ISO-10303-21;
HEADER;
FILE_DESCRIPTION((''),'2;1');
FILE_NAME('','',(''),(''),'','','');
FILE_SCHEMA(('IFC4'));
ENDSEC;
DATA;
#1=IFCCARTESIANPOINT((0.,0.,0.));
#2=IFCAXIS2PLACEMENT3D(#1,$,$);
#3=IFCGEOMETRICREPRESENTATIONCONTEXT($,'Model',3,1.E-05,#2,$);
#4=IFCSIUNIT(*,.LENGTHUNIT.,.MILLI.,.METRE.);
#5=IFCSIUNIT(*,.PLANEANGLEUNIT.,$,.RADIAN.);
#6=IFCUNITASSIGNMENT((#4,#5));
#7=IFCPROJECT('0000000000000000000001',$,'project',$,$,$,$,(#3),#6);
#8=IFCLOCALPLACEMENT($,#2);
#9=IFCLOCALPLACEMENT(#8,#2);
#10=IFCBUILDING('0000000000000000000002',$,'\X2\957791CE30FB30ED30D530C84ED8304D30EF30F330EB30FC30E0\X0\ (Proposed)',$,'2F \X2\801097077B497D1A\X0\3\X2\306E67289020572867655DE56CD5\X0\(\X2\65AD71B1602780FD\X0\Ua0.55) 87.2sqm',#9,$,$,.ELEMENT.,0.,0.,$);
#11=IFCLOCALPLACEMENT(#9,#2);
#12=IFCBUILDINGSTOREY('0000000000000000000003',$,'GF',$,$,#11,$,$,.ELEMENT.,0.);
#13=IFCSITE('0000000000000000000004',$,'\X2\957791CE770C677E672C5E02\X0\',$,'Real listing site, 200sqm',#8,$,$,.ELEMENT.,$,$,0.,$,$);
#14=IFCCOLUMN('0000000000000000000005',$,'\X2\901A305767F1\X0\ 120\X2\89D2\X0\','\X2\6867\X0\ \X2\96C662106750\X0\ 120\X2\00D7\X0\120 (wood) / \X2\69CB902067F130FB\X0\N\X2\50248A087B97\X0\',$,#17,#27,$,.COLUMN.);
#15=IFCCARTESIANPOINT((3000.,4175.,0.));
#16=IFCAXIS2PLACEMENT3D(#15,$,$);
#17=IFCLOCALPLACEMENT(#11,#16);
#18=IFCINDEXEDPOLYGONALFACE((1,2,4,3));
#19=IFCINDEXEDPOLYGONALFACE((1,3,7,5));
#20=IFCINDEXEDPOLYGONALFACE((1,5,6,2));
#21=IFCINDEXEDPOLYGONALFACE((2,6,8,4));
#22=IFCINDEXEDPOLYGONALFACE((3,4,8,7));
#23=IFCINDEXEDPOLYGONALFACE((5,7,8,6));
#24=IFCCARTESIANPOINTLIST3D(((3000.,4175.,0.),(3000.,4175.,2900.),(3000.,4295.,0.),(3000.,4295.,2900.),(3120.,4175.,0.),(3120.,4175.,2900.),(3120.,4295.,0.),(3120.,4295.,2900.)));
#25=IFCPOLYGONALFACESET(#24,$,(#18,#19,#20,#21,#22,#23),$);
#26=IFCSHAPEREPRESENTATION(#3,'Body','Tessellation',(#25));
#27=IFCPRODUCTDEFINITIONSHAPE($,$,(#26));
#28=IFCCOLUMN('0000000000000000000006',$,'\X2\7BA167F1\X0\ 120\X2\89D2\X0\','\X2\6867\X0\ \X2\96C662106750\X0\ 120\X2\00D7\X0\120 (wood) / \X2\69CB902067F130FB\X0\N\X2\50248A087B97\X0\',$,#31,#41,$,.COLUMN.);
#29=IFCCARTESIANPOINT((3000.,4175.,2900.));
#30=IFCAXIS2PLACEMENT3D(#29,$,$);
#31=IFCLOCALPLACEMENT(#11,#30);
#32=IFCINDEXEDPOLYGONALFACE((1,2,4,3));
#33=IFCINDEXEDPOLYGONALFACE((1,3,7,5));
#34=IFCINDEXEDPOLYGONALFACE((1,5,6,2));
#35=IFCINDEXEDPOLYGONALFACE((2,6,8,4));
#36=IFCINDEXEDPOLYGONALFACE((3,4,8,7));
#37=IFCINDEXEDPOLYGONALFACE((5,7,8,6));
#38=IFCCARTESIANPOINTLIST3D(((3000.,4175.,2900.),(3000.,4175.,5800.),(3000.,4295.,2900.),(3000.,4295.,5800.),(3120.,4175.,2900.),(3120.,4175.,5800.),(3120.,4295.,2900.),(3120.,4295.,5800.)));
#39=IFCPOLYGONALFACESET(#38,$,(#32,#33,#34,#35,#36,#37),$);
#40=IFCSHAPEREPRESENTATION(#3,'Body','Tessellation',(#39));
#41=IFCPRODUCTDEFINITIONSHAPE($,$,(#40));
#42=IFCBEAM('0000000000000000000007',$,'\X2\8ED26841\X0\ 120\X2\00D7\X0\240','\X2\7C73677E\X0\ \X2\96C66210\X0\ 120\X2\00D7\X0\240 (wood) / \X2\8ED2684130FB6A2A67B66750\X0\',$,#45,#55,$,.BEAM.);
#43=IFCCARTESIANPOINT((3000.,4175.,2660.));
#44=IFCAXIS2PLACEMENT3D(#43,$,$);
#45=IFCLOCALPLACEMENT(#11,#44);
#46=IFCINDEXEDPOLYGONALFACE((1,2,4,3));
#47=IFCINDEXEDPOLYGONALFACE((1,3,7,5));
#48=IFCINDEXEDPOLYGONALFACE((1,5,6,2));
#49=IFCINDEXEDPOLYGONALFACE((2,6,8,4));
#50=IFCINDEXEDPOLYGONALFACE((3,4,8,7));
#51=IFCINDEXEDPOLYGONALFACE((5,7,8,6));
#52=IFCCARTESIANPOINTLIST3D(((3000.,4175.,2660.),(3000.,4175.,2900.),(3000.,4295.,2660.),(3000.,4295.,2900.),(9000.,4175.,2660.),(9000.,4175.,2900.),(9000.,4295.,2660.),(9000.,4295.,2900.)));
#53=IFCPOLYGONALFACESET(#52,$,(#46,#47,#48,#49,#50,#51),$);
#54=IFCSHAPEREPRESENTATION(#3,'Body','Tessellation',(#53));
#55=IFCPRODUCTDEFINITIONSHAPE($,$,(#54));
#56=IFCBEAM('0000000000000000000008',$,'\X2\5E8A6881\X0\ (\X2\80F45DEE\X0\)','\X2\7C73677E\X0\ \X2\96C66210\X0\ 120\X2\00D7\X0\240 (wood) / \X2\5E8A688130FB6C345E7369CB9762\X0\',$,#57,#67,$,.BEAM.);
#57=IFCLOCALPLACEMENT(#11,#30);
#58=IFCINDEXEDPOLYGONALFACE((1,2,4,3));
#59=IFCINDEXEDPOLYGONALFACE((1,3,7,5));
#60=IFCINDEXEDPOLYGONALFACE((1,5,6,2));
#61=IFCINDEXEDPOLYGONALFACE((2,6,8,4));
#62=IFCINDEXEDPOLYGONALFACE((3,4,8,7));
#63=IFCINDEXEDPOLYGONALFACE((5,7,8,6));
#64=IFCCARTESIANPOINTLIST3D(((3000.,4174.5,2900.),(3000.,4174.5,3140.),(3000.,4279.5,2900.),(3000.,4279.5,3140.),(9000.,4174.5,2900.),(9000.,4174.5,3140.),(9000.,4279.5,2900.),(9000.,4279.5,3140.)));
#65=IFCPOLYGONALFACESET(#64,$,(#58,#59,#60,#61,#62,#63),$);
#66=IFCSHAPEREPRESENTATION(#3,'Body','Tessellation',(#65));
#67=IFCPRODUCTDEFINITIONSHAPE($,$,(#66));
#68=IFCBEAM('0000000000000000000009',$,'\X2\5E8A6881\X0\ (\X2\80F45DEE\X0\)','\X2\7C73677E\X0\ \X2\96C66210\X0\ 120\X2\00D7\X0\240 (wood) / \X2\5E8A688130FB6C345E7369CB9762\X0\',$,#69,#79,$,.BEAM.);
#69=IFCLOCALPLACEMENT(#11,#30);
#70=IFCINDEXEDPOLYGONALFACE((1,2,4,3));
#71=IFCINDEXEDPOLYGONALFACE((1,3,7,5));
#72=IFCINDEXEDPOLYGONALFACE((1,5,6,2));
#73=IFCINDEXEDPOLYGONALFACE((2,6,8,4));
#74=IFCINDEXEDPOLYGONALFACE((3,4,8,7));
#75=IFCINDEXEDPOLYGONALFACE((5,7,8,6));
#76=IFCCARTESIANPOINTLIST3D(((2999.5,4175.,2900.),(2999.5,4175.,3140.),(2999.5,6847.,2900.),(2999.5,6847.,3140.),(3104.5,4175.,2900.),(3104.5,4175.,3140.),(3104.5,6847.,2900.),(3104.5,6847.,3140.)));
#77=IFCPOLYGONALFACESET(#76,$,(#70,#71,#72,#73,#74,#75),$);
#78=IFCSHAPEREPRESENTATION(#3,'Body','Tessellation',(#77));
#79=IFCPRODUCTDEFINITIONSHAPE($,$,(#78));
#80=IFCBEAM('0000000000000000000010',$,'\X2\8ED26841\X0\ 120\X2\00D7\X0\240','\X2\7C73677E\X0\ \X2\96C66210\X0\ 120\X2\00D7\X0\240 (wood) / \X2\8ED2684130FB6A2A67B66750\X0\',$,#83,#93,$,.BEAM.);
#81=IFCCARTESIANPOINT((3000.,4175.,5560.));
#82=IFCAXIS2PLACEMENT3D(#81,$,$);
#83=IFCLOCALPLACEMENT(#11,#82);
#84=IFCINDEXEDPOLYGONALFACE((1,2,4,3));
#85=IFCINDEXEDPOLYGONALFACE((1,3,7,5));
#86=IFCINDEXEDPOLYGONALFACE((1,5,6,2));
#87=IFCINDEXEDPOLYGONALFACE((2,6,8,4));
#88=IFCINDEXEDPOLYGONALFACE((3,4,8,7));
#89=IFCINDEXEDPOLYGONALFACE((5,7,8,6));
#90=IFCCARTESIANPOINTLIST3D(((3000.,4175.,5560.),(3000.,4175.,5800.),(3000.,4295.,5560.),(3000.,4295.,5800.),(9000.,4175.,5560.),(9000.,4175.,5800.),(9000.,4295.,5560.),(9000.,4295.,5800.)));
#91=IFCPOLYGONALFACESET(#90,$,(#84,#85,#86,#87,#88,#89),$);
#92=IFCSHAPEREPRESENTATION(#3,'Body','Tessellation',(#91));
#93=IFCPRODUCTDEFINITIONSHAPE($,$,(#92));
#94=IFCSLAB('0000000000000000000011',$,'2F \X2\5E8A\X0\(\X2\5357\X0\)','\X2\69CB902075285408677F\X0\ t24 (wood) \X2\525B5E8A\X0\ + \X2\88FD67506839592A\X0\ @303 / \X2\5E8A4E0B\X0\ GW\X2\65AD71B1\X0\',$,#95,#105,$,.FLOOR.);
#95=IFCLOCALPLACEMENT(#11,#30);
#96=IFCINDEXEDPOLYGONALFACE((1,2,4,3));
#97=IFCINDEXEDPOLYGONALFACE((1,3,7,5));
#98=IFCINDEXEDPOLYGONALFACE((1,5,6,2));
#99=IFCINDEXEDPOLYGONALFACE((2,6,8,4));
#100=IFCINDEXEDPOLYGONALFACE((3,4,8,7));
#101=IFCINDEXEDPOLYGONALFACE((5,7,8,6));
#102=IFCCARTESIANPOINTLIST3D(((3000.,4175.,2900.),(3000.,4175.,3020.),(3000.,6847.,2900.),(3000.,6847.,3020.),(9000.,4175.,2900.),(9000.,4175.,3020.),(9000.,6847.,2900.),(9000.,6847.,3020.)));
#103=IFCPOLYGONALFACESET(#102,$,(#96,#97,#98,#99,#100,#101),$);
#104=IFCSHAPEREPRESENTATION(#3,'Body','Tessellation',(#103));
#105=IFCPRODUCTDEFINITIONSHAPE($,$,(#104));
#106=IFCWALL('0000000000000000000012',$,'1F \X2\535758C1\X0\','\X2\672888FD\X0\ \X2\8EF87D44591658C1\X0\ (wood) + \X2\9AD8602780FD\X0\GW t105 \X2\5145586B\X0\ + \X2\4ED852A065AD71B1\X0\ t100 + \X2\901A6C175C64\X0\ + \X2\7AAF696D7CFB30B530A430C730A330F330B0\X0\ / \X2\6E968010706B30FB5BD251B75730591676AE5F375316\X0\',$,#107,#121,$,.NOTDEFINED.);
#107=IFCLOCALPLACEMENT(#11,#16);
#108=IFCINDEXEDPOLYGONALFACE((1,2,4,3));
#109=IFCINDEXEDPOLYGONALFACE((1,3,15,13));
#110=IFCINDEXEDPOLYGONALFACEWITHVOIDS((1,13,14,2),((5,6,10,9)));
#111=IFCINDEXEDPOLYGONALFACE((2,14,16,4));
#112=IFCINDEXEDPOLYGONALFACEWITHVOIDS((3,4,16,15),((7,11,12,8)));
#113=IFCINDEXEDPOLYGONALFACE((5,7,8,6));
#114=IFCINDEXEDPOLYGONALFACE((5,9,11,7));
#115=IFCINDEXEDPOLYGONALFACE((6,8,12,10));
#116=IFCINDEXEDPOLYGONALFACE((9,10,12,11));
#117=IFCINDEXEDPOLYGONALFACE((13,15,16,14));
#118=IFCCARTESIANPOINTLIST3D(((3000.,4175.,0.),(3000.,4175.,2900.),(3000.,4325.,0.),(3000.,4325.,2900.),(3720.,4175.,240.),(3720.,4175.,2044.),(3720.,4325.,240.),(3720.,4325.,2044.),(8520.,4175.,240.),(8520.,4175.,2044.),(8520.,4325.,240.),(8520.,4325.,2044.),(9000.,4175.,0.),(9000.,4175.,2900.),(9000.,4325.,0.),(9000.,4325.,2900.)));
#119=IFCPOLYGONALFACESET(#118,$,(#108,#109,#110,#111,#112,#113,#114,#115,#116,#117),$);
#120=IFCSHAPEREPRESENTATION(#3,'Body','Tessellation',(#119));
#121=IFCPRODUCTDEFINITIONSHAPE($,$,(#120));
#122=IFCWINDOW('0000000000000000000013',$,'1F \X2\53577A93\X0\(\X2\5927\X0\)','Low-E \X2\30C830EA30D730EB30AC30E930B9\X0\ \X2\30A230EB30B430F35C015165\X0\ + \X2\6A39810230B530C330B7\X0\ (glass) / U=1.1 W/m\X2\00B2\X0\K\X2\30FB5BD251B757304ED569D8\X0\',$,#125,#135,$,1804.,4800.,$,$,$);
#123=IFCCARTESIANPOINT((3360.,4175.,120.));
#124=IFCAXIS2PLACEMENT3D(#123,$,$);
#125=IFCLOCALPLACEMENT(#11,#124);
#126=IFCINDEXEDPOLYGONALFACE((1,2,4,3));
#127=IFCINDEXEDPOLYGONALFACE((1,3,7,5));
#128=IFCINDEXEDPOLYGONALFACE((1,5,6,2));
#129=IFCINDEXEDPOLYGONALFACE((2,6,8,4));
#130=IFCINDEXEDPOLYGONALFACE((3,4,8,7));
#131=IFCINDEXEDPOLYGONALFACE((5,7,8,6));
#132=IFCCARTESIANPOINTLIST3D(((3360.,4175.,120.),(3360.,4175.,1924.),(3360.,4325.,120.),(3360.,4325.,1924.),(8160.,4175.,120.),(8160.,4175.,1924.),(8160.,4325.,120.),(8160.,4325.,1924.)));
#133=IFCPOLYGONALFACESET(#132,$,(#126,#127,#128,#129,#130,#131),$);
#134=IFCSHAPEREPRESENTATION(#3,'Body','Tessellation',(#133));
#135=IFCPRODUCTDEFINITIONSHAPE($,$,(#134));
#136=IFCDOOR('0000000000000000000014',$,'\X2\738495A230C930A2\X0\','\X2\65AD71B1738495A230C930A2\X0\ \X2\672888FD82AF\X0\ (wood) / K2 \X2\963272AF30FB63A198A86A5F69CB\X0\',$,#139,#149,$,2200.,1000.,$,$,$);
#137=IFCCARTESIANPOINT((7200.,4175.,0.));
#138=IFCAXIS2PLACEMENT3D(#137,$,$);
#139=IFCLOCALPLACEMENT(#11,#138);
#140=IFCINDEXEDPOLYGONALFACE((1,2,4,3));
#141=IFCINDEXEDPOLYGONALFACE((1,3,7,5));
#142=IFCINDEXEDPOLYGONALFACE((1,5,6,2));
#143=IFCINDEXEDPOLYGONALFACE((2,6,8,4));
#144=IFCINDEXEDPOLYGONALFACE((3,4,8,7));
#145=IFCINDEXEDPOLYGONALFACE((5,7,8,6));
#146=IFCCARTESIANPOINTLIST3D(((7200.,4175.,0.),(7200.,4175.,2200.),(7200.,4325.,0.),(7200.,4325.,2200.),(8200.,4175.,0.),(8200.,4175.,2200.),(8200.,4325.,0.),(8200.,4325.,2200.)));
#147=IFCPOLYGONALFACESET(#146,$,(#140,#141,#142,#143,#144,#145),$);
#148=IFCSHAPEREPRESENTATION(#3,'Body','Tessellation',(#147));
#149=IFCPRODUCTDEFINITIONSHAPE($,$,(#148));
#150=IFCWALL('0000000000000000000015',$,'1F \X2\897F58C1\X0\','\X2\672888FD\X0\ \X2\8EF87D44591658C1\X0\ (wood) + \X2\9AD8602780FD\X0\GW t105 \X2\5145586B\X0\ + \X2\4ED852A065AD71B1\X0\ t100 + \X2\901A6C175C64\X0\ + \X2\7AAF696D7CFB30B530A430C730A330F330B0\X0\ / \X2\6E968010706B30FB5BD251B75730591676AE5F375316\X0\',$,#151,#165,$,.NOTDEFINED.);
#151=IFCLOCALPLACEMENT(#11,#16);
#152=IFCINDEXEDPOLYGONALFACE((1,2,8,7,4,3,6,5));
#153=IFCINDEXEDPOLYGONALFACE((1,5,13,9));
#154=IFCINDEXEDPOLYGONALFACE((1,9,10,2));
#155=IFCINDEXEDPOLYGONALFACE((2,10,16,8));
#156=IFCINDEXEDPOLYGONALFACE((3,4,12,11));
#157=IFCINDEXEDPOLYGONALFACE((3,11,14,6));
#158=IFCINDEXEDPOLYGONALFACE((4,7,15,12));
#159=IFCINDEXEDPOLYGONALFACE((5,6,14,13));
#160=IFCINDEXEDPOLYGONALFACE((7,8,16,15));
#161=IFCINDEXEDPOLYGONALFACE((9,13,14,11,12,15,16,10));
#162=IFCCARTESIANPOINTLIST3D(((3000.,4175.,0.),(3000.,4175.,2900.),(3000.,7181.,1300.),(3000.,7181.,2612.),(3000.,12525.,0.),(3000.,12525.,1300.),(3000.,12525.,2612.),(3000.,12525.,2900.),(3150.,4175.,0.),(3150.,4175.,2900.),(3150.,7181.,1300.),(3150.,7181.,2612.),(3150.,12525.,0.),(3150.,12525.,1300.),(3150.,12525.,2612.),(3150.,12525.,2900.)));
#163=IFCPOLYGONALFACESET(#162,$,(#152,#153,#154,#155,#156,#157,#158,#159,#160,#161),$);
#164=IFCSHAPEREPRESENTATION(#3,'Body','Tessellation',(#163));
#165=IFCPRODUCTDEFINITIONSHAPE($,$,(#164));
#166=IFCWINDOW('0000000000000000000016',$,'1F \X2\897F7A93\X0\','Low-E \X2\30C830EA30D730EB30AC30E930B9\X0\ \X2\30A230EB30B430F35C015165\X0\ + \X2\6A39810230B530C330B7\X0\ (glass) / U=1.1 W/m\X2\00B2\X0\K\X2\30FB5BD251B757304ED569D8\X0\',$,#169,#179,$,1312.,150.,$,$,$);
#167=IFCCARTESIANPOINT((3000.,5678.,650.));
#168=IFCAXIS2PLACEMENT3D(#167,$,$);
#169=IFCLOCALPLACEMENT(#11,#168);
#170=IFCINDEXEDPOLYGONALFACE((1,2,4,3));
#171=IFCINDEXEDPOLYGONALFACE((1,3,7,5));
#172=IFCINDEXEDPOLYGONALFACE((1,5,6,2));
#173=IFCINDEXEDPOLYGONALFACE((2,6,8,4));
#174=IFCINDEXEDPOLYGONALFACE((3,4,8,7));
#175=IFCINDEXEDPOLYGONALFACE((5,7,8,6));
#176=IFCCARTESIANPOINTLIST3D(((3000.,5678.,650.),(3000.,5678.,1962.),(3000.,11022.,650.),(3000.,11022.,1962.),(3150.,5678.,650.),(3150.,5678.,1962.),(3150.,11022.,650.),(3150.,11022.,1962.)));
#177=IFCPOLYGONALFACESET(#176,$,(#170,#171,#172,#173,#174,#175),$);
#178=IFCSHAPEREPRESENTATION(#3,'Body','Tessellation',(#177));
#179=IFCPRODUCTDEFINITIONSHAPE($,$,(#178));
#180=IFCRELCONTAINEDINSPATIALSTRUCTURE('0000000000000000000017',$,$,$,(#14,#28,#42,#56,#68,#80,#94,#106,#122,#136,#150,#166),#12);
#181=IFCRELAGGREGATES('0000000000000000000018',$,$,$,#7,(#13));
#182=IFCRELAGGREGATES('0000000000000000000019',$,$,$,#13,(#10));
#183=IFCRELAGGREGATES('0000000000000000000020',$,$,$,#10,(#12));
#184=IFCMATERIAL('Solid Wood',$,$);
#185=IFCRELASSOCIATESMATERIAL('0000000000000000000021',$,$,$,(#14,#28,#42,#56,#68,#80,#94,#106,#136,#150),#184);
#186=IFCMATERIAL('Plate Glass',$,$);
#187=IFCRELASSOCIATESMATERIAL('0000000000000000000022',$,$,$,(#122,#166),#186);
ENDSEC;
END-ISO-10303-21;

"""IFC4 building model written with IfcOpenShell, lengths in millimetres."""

from ifc_helpers import new_model, si_unit, frame, frame_2d, origin, place, context, project, spatial, rectangle, extrude, material, element, fill, save


model = new_model("IFC4")

# Units and contexts
model_context = context("Model", 3, precision=1e-05, world=origin())
ifc_project = project(units=[si_unit("LENGTHUNIT", "METRE", prefix="MILLI"), si_unit("PLANEANGLEUNIT", "RADIAN")], contexts=[model_context])

# Site, building, storey
site_placement = place(None, origin())
site = spatial("IfcSite", under=ifc_project, at=site_placement, Name="長野県松本市", ObjectType="Real listing site, 200sqm", CompositionType="ELEMENT", RefElevation=0.0)
building_placement = place(site_placement, origin())
building = spatial("IfcBuilding", under=site, at=building_placement, Name="長野・ロフト付きワンルーム (Proposed)", ObjectType="2F 耐震等級3の木造在来工法(断熱性能Ua0.55) 87.2sqm", CompositionType="ELEMENT", ElevationOfRefHeight=0.0, ElevationOfTerrain=0.0)
storey_placement = place(building_placement, origin())
storey = spatial("IfcBuildingStorey", under=building, at=storey_placement, Name="GF", CompositionType="ELEMENT", Elevation=0.0)

# Columns
ifc_material_1 = material(Name="Solid Wood")
column_1_placement = place(storey_placement, frame((3000.0, 4175.0, 0.0)))
element("IfcColumn", 1, at=column_1_placement, inside=storey, material=ifc_material_1, Name="通し柱 120角", Description="桧 集成材 120×120 (wood) / 構造柱・N値計算", PredefinedType="COLUMN", context=model_context, shape_type="SweptSolid", body=[
    extrude(rectangle(XDim=120.0, YDim=120.0, at=frame_2d((60.0, 60.0))), frame((3000.0, 4175.0, 0.0)), (0.0, 0.0, 1.0), 2900.0),
])
column_2_placement = place(storey_placement, frame((3000.0, 4175.0, 2900.0)))
element("IfcColumn", 2, at=column_2_placement, inside=storey, material=ifc_material_1, Name="管柱 120角", Description="桧 集成材 120×120 (wood) / 構造柱・N値計算", PredefinedType="COLUMN", context=model_context, shape_type="SweptSolid", body=[
    extrude(rectangle(XDim=120.0, YDim=120.0, at=frame_2d((60.0, 60.0))), frame((3000.0, 4175.0, 2900.0)), (0.0, 0.0, 1.0), 2900.0),
])

# Beams
beam_1_placement = place(storey_placement, frame((3000.0, 4175.0, 2660.0)))
element("IfcBeam", 3, at=beam_1_placement, inside=storey, material=ifc_material_1, Name="軒桁 120×240", Description="米松 集成 120×240 (wood) / 軒桁・横架材", PredefinedType="BEAM", context=model_context, shape_type="SweptSolid", body=[
    extrude(rectangle(XDim=6000.0, YDim=120.0, at=frame_2d((3000.0, 60.0))), frame((3000.0, 4175.0, 2660.0)), (0.0, 0.0, 1.0), 240.0),
])
beam_2_placement = place(storey_placement, frame((3000.0, 4175.0, 2900.0)))
element("IfcBeam", 4, at=beam_2_placement, inside=storey, material=ifc_material_1, Name="床梁 (胴差)", Description="米松 集成 120×240 (wood) / 床梁・水平構面", PredefinedType="BEAM", context=model_context, shape_type="SweptSolid", body=[
    extrude(rectangle(XDim=6000.0, YDim=105.0, at=frame_2d((3000.0, 52.0))), frame((3000.0, 4175.0, 2900.0)), (0.0, 0.0, 1.0), 240.0),
])
beam_3_placement = place(storey_placement, frame((3000.0, 4175.0, 2900.0)))
element("IfcBeam", 5, at=beam_3_placement, inside=storey, material=ifc_material_1, Name="床梁 (胴差)", Description="米松 集成 120×240 (wood) / 床梁・水平構面", PredefinedType="BEAM", context=model_context, shape_type="SweptSolid", body=[
    extrude(rectangle(XDim=105.0, YDim=2672.0, at=frame_2d((52.0, 1336.0))), frame((3000.0, 4175.0, 2900.0)), (0.0, 0.0, 1.0), 240.0),
])
beam_4_placement = place(storey_placement, frame((3000.0, 4175.0, 5560.0)))
element("IfcBeam", 6, at=beam_4_placement, inside=storey, material=ifc_material_1, Name="軒桁 120×240", Description="米松 集成 120×240 (wood) / 軒桁・横架材", PredefinedType="BEAM", context=model_context, shape_type="SweptSolid", body=[
    extrude(rectangle(XDim=6000.0, YDim=120.0, at=frame_2d((3000.0, 60.0))), frame((3000.0, 4175.0, 5560.0)), (0.0, 0.0, 1.0), 240.0),
])

# Slab
slab_1_placement = place(storey_placement, frame((3000.0, 4175.0, 2900.0)))
element("IfcSlab", 7, at=slab_1_placement, inside=storey, material=ifc_material_1, Name="2F 床(南)", Description="構造用合板 t24 (wood) 剛床 + 製材根太 @303 / 床下 GW断熱", PredefinedType="FLOOR", context=model_context, shape_type="SweptSolid", body=[
    extrude(rectangle(XDim=6000.0, YDim=2672.0, at=frame_2d((3000.0, 1336.0))), frame((3000.0, 4175.0, 2900.0)), (0.0, 0.0, 1.0), 120.0),
])

# Wall, openings, window, door
wall_1_placement = place(storey_placement, frame((3000.0, 4175.0, 0.0)))
wall_1 = element("IfcWall", 8, at=wall_1_placement, inside=storey, material=ifc_material_1, Name="1F 南壁", Description="木製 軸組外壁 (wood) + 高性能GW t105 充填 + 付加断熱 t100 + 通気層 + 窯業系サイディング / 準耐火・寒冷地外皮強化", PredefinedType="NOTDEFINED", context=model_context, shape_type="SweptSolid", body=[
    extrude(rectangle(XDim=6000.0, YDim=150.0, at=frame_2d((3000.0, 75.0))), frame((3000.0, 4175.0, 0.0)), (0.0, 0.0, 1.0), 2900.0),
])
opening_1_placement = place(storey_placement, frame((3360.0, 4175.0, 120.0)))
opening_1 = element("IfcOpeningElement", 9, at=opening_1_placement, cuts=wall_1, PredefinedType="NOTDEFINED", context=model_context, shape_type="SweptSolid", body=[
    extrude(rectangle(XDim=4800.0, YDim=150.0, at=frame_2d((2400.0, 75.0))), frame((3360.0, 4175.0, 120.0)), (0.0, 0.0, 1.0), 1804.0),
])
opening_2_placement = place(storey_placement, frame((7200.0, 4175.0, 0.0)))
opening_2 = element("IfcOpeningElement", 10, at=opening_2_placement, cuts=wall_1, PredefinedType="NOTDEFINED", context=model_context, shape_type="SweptSolid", body=[
    extrude(rectangle(XDim=1000.0, YDim=150.0, at=frame_2d((500.0, 75.0))), frame((7200.0, 4175.0, 0.0)), (0.0, 0.0, 1.0), 2200.0),
])
ifc_material_2 = material(Name="Plate Glass")
window_1_placement = place(storey_placement, frame((3360.0, 4175.0, 120.0)))
window_1 = element("IfcWindow", 11, at=window_1_placement, inside=storey, material=ifc_material_2, Name="1F 南窓(大)", Description="Low-E トリプルガラス アルゴン封入 + 樹脂サッシ (glass) / U=1.1 W/m²K・寒冷地仕様", OverallHeight=1804.0, OverallWidth=4800.0, context=model_context, shape_type="SweptSolid", body=[
    extrude(rectangle(XDim=4800.0, YDim=150.0, at=frame_2d((2400.0, 75.0))), frame((3360.0, 4175.0, 120.0)), (0.0, 0.0, 1.0), 1804.0),
])
fill(opening_1, window_1)
door_placement = place(storey_placement, frame((7200.0, 4175.0, 0.0)))
door = element("IfcDoor", 12, at=door_placement, inside=storey, material=ifc_material_1, Name="玄関ドア", Description="断熱玄関ドア 木製芯 (wood) / K2 防犯・採風機構", OverallHeight=2200.0, OverallWidth=1000.0, context=model_context, shape_type="SweptSolid", body=[
    extrude(rectangle(XDim=1000.0, YDim=150.0, at=frame_2d((500.0, 75.0))), frame((7200.0, 4175.0, 0.0)), (0.0, 0.0, 1.0), 2200.0),
])
fill(opening_2, door)

# Wall, opening, window
wall_2_placement = place(storey_placement, frame((3000.0, 4175.0, 0.0)))
wall_2 = element("IfcWall", 13, at=wall_2_placement, inside=storey, material=ifc_material_1, Name="1F 西壁", Description="木製 軸組外壁 (wood) + 高性能GW t105 充填 + 付加断熱 t100 + 通気層 + 窯業系サイディング / 準耐火・寒冷地外皮強化", PredefinedType="NOTDEFINED", context=model_context, shape_type="SweptSolid", body=[
    extrude(rectangle(XDim=150.0, YDim=8350.0, at=frame_2d((75.0, 4175.0))), frame((3000.0, 4175.0, 0.0)), (0.0, 0.0, 1.0), 2900.0),
])
opening_3_placement = place(storey_placement, frame((3000.0, 5678.0, 650.0)))
opening_3 = element("IfcOpeningElement", 14, at=opening_3_placement, cuts=wall_2, PredefinedType="NOTDEFINED", context=model_context, shape_type="SweptSolid", body=[
    extrude(rectangle(XDim=150.0, YDim=5344.0, at=frame_2d((75.0, 2672.0))), frame((3000.0, 5678.0, 650.0)), (0.0, 0.0, 1.0), 1312.0),
])
window_2_placement = place(storey_placement, frame((3000.0, 5678.0, 650.0)))
window_2 = element("IfcWindow", 15, at=window_2_placement, inside=storey, material=ifc_material_2, Name="1F 西窓", Description="Low-E トリプルガラス アルゴン封入 + 樹脂サッシ (glass) / U=1.1 W/m²K・寒冷地仕様", OverallHeight=1312.0, OverallWidth=150.0, context=model_context, shape_type="SweptSolid", body=[
    extrude(rectangle(XDim=150.0, YDim=5344.0, at=frame_2d((75.0, 2672.0))), frame((3000.0, 5678.0, 650.0)), (0.0, 0.0, 1.0), 1312.0),
])
fill(opening_3, window_2)

save(model, "model.ifc")
